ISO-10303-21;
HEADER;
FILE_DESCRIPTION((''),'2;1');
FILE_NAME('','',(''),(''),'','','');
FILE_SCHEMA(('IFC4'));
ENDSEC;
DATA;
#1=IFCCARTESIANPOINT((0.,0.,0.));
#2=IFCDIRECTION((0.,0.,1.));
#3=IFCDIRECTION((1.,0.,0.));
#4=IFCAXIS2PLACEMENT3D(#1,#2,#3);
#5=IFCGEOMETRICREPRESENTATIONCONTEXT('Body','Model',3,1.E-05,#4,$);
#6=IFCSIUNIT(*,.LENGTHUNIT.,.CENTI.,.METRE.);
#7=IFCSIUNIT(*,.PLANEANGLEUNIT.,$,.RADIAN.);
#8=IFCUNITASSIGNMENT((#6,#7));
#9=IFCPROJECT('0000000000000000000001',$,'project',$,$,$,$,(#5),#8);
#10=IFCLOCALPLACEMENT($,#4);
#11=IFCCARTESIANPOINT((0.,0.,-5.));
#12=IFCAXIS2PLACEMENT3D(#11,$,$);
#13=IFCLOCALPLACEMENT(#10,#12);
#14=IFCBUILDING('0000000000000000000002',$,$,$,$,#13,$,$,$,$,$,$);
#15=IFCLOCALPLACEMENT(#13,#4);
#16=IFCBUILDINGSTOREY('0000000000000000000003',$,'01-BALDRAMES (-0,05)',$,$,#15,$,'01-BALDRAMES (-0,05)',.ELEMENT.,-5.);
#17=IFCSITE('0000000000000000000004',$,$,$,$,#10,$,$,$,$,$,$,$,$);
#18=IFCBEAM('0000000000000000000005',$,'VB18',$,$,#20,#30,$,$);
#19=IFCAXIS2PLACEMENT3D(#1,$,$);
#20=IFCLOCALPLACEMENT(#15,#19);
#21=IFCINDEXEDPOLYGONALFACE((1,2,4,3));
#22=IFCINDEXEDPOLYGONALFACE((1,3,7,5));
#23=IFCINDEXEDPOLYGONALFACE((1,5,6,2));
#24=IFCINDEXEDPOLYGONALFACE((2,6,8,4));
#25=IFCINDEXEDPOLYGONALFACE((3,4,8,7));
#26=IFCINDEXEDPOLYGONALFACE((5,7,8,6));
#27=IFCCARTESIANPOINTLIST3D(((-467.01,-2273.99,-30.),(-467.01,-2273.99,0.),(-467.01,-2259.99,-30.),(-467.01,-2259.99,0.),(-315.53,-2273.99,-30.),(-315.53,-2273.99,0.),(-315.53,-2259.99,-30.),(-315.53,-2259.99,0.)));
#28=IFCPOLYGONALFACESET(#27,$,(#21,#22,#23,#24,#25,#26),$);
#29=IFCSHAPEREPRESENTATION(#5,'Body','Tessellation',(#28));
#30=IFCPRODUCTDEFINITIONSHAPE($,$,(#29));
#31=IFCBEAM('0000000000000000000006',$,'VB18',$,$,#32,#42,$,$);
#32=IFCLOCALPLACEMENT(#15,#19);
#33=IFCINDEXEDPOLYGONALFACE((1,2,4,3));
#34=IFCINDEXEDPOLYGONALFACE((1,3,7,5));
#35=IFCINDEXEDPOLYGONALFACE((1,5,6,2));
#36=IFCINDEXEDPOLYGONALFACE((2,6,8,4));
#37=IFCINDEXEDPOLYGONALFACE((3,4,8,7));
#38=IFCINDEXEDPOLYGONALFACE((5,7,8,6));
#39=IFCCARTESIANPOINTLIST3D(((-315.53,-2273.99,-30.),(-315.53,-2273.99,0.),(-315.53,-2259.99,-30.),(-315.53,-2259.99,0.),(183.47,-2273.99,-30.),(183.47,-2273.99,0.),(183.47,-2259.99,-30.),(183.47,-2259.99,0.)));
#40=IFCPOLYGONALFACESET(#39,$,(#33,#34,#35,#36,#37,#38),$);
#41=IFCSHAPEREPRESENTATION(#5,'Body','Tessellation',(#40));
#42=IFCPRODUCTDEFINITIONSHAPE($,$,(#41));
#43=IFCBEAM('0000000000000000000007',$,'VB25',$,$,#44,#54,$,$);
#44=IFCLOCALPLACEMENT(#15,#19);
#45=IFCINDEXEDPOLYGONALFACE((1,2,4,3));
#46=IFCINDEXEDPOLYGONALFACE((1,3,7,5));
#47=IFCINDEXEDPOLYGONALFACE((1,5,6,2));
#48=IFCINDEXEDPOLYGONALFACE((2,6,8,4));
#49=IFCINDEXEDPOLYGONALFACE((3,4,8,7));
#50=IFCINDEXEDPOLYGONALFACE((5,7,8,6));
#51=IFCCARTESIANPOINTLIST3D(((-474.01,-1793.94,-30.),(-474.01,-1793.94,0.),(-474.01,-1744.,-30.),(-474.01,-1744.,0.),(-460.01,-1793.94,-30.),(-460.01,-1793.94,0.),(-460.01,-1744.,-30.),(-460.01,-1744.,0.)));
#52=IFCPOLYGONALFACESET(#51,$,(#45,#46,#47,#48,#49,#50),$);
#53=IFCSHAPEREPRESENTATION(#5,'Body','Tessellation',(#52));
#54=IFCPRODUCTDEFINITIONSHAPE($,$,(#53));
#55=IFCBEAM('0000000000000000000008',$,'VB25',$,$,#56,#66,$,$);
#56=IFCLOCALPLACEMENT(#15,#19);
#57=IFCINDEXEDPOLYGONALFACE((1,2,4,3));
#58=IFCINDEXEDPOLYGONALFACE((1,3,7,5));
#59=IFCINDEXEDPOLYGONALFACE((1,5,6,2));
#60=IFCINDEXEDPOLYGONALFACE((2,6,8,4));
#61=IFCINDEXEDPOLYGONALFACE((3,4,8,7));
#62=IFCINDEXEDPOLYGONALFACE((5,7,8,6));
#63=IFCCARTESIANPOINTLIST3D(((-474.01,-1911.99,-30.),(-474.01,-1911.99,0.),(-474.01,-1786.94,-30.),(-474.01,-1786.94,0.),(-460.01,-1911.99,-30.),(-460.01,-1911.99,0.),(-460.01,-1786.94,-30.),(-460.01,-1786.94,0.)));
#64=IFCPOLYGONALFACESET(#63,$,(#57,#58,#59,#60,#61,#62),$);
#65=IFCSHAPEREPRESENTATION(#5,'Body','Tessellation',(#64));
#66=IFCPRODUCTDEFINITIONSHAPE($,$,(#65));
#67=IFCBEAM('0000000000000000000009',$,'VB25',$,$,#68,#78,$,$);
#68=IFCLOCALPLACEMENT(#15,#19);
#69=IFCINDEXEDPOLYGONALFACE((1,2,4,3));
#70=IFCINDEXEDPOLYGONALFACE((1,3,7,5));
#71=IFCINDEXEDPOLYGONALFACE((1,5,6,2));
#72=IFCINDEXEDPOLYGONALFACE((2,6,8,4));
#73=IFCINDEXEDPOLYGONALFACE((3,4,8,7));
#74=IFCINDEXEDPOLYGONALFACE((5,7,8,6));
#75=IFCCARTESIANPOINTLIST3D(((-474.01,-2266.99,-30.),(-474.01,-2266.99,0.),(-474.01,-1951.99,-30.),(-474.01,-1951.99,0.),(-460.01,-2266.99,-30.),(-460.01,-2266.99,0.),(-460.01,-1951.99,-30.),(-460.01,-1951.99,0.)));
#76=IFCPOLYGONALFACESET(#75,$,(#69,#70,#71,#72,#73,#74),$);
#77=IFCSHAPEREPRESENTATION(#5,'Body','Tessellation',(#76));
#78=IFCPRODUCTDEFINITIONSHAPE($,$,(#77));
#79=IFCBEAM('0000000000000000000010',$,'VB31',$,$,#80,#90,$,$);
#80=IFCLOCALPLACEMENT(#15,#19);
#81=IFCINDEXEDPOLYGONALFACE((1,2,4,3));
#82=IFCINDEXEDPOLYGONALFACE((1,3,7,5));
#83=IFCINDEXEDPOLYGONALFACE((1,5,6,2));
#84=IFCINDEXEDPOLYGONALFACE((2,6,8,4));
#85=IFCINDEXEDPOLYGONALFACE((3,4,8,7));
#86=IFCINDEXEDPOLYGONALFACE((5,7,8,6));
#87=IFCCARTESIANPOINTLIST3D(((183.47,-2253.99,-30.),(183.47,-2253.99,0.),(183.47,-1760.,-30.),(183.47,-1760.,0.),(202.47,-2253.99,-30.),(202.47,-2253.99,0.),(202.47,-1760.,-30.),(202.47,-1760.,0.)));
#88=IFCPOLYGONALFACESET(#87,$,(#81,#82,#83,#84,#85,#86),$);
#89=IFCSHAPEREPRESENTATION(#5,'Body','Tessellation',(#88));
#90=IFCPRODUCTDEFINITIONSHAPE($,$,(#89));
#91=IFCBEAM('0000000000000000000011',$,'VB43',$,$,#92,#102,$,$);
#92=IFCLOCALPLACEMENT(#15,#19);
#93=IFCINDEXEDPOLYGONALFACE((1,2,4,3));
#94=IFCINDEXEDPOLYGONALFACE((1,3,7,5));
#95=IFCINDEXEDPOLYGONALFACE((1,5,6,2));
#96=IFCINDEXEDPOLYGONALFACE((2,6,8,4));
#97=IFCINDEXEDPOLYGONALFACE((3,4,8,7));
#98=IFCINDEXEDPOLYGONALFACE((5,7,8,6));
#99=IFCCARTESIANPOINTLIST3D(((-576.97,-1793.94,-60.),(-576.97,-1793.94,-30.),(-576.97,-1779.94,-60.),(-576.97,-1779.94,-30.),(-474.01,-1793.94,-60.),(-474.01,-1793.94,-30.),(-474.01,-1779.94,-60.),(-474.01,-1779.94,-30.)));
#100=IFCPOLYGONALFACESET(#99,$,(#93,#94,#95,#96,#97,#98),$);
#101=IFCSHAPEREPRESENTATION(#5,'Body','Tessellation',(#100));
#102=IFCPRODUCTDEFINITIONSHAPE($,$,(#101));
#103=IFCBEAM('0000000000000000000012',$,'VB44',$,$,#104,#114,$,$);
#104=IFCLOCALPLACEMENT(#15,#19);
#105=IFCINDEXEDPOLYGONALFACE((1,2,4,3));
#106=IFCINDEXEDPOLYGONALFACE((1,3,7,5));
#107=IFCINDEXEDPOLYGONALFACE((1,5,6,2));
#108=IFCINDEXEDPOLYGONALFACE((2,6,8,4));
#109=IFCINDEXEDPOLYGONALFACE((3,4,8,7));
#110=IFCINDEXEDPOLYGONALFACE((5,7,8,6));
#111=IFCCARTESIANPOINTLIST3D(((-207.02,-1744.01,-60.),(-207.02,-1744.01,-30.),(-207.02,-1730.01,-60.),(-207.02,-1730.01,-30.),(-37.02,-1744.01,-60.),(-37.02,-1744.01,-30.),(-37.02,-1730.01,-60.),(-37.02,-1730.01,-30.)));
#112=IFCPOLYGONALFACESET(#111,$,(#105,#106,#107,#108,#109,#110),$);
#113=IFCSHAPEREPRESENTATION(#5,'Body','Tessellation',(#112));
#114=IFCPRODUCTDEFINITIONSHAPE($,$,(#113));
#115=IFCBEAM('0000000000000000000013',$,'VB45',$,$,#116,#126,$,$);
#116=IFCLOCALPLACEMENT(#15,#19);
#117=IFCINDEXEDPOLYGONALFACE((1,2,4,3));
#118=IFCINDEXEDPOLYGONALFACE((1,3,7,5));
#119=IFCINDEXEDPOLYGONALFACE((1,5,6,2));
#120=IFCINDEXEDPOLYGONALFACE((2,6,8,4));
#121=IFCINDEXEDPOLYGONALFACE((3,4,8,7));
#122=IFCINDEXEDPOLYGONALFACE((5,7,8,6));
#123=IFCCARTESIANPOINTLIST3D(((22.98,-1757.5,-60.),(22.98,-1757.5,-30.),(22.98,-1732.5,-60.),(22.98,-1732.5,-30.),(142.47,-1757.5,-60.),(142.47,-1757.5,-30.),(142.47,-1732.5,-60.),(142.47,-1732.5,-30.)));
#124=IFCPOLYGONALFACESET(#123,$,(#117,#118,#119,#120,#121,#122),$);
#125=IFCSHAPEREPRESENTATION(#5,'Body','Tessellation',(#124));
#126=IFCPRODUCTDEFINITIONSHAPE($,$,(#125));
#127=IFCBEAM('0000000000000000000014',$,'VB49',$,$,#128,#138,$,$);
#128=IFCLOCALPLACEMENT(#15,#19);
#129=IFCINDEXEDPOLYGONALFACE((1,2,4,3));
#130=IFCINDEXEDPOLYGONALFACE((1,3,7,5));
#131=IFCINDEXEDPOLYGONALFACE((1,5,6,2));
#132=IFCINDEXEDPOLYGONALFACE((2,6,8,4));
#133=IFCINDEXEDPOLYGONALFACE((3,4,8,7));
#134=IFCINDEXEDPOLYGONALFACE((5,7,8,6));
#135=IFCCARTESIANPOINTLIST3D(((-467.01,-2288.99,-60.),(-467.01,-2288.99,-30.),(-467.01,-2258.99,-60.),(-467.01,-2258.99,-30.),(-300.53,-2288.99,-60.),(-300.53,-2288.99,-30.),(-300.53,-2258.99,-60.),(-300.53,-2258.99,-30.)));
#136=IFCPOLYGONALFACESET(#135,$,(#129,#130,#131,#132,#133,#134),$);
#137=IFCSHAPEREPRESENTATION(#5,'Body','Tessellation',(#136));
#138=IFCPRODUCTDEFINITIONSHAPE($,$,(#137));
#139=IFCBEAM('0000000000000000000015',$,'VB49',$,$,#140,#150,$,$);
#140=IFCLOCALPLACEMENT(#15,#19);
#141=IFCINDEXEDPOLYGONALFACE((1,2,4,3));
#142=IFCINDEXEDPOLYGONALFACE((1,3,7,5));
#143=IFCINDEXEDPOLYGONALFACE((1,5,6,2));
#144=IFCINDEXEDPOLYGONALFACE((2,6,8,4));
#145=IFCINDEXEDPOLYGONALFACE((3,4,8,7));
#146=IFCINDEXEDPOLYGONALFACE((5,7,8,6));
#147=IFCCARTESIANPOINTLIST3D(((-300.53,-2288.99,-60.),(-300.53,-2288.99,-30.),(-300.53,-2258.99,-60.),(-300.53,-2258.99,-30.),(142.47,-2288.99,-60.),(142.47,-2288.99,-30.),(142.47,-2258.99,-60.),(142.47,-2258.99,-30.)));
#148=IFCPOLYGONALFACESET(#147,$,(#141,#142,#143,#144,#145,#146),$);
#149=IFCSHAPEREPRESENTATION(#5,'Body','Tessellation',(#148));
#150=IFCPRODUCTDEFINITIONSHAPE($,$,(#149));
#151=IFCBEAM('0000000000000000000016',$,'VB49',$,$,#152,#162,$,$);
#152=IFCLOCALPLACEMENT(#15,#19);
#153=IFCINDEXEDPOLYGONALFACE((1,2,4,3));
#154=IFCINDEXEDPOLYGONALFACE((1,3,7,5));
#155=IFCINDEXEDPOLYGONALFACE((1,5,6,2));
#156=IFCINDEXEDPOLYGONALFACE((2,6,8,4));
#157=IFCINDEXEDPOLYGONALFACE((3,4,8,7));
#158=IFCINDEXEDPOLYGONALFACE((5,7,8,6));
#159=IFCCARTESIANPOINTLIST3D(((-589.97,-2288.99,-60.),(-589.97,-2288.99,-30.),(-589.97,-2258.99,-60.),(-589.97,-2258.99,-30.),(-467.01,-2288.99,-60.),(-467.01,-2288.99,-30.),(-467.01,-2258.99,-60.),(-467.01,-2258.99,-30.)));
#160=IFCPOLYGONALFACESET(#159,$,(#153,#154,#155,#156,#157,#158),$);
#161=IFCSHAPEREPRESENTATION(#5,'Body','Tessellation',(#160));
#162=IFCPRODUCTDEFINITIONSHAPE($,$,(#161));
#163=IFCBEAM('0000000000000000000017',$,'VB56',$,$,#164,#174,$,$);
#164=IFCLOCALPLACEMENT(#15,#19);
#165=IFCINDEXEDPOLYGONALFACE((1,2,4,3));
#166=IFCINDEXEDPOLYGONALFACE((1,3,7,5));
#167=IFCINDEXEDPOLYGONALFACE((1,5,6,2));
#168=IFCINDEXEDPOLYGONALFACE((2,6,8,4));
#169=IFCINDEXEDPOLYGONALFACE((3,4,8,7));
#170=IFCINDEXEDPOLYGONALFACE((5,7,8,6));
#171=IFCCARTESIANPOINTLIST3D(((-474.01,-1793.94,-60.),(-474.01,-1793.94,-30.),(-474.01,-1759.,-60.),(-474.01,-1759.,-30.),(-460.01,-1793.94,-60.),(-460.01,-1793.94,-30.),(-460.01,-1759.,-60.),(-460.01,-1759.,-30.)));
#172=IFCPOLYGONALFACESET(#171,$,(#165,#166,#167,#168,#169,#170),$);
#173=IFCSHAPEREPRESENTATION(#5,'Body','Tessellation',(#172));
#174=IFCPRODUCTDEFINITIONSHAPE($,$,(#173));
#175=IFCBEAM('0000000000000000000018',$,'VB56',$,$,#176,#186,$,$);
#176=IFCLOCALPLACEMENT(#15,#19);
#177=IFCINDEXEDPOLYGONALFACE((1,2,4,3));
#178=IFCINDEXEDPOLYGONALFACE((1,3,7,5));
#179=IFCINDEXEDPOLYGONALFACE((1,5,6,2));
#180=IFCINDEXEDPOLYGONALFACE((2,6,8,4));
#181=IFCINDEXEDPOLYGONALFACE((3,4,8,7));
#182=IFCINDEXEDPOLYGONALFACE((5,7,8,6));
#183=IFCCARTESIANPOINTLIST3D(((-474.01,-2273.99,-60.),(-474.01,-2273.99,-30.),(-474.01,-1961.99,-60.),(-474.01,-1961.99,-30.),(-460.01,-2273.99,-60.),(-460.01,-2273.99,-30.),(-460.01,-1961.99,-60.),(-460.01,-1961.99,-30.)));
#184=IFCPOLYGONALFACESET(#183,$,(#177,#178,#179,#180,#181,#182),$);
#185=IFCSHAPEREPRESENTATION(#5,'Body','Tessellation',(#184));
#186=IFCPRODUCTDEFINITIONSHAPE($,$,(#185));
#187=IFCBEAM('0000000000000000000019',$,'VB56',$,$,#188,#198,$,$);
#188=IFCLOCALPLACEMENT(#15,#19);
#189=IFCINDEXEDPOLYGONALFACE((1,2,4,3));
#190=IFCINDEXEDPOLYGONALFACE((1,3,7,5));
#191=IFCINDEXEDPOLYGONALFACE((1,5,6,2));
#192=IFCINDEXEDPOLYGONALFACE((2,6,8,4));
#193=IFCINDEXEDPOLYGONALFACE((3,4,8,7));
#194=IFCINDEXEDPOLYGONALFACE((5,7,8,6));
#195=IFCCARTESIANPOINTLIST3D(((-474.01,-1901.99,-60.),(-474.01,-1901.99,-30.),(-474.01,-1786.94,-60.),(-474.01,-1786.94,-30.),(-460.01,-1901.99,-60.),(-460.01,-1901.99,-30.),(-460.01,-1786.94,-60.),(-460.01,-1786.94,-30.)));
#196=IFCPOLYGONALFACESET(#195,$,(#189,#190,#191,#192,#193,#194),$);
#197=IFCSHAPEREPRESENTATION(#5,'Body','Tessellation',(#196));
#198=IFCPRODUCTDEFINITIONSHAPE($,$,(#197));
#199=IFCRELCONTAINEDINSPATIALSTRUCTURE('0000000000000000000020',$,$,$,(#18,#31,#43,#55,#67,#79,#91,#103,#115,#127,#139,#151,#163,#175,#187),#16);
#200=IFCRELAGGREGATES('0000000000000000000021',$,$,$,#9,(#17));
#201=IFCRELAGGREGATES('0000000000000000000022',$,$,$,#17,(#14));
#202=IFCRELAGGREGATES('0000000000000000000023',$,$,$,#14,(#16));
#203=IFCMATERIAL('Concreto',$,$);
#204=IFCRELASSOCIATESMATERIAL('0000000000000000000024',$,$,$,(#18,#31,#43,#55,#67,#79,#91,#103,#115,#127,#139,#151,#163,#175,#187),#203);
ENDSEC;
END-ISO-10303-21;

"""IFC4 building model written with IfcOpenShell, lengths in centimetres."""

from ifc_helpers import new_model, si_unit, frame, origin_with_axes, origin_2d_with_axis, place, context, project, spatial, rectangle, extrude, material, element, save


model = new_model("IFC4")

# Units and contexts
model_context = context("Model", 3, precision=1e-05, world=origin_with_axes(), identifier="Body")
ifc_project = project(units=[si_unit("LENGTHUNIT", "METRE", prefix="CENTI"), si_unit("PLANEANGLEUNIT", "RADIAN")], contexts=[model_context])

# Site, building, storey
site_placement = place(None, origin_with_axes())
site = spatial("IfcSite", under=ifc_project, at=site_placement)
building_placement = place(site_placement, frame((0.0, 0.0, -5.0)))
building = spatial("IfcBuilding", under=site, at=building_placement)
storey_placement = place(building_placement, origin_with_axes())
storey = spatial("IfcBuildingStorey", under=building, at=storey_placement, Name="01-BALDRAMES (-0,05)", LongName="01-BALDRAMES (-0,05)", CompositionType="ELEMENT", Elevation=-5.0)

# Shared definitions
ifc_material = material(Name="Concreto")

# Beams
beam_1_placement = place(storey_placement, frame((-391.27, -2266.99, 0.0), z_axis=(0.0, 0.0, 1.0), x_axis=(1.0, 0.0, 0.0)))
element("IfcBeam", 1, at=beam_1_placement, inside=storey, material=ifc_material, Name="VB18", context=model_context, shape_type="SolidModel", body=[
    extrude(rectangle(XDim=14.0, YDim=30.0, at=origin_2d_with_axis()), frame((-75.74, 0.0, -15.0), z_axis=(1.0, 0.0, 0.0), x_axis=(0.0, -1.0, 0.0)), (0.0, 0.0, 1.0), 151.48),
])
beam_2_placement = place(storey_placement, frame((-66.03, -2266.99, 0.0), z_axis=(0.0, 0.0, 1.0), x_axis=(1.0, 0.0, 0.0)))
element("IfcBeam", 2, at=beam_2_placement, inside=storey, material=ifc_material, Name="VB18", context=model_context, shape_type="SolidModel", body=[
    extrude(rectangle(XDim=14.0, YDim=30.0, at=origin_2d_with_axis()), frame((-249.5, 0.0, -15.0), z_axis=(1.0, 0.0, 0.0), x_axis=(0.0, -1.0, 0.0)), (0.0, 0.0, 1.0), 499.0),
])
beam_3_placement = place(storey_placement, frame((-467.01, -1768.97, 0.0), z_axis=(0.0, 0.0, 1.0), x_axis=(1.0, 0.0, 0.0)))
element("IfcBeam", 3, at=beam_3_placement, inside=storey, material=ifc_material, Name="VB25", context=model_context, shape_type="SolidModel", body=[
    extrude(rectangle(XDim=14.0, YDim=30.0, at=origin_2d_with_axis()), frame((0.0, -24.97, -15.0), z_axis=(0.0, 1.0, 0.0), x_axis=(1.0, 0.0, 0.0)), (0.0, 0.0, 1.0), 49.94),
])
beam_4_placement = place(storey_placement, frame((-467.01, -1849.46, 0.0), z_axis=(0.0, 0.0, 1.0), x_axis=(1.0, 0.0, 0.0)))
element("IfcBeam", 4, at=beam_4_placement, inside=storey, material=ifc_material, Name="VB25", context=model_context, shape_type="SolidModel", body=[
    extrude(rectangle(XDim=14.0, YDim=30.0, at=origin_2d_with_axis()), frame((0.0, -62.52, -15.0), z_axis=(0.0, 1.0, 0.0), x_axis=(1.0, 0.0, 0.0)), (0.0, 0.0, 1.0), 125.05),
])
beam_5_placement = place(storey_placement, frame((-467.01, -2109.49, 0.0), z_axis=(0.0, 0.0, 1.0), x_axis=(1.0, 0.0, 0.0)))
element("IfcBeam", 5, at=beam_5_placement, inside=storey, material=ifc_material, Name="VB25", context=model_context, shape_type="SolidModel", body=[
    extrude(rectangle(XDim=14.0, YDim=30.0, at=origin_2d_with_axis()), frame((0.0, -157.5, -15.0), z_axis=(0.0, 1.0, 0.0), x_axis=(1.0, 0.0, 0.0)), (0.0, 0.0, 1.0), 315.0),
])
beam_6_placement = place(storey_placement, frame((192.97, -2006.99, 0.0), z_axis=(0.0, 0.0, 1.0), x_axis=(1.0, 0.0, 0.0)))
element("IfcBeam", 6, at=beam_6_placement, inside=storey, material=ifc_material, Name="VB31", context=model_context, shape_type="SolidModel", body=[
    extrude(rectangle(XDim=19.0, YDim=30.0, at=origin_2d_with_axis()), frame((0.0, -247.0, -15.0), z_axis=(0.0, 1.0, 0.0), x_axis=(1.0, 0.0, 0.0)), (0.0, 0.0, 1.0), 493.99),
])
beam_7_placement = place(storey_placement, frame((-525.49, -1786.94, -30.0), z_axis=(0.0, 0.0, 1.0), x_axis=(1.0, 0.0, 0.0)))
element("IfcBeam", 7, at=beam_7_placement, inside=storey, material=ifc_material, Name="VB43", context=model_context, shape_type="SolidModel", body=[
    extrude(rectangle(XDim=14.0, YDim=30.0, at=origin_2d_with_axis()), frame((-51.48, 0.0, -15.0), z_axis=(1.0, 0.0, 0.0), x_axis=(0.0, -1.0, 0.0)), (0.0, 0.0, 1.0), 102.96),
])
beam_8_placement = place(storey_placement, frame((-122.02, -1737.01, -30.0), z_axis=(0.0, 0.0, 1.0), x_axis=(1.0, 0.0, 0.0)))
element("IfcBeam", 8, at=beam_8_placement, inside=storey, material=ifc_material, Name="VB44", context=model_context, shape_type="SolidModel", body=[
    extrude(rectangle(XDim=14.0, YDim=30.0, at=origin_2d_with_axis()), frame((-85.0, 0.0, -15.0), z_axis=(1.0, 0.0, 0.0), x_axis=(0.0, -1.0, 0.0)), (0.0, 0.0, 1.0), 170.0),
])
beam_9_placement = place(storey_placement, frame((82.72, -1745.0, -30.0), z_axis=(0.0, 0.0, 1.0), x_axis=(1.0, 0.0, 0.0)))
element("IfcBeam", 9, at=beam_9_placement, inside=storey, material=ifc_material, Name="VB45", context=model_context, shape_type="SolidModel", body=[
    extrude(rectangle(XDim=25.0, YDim=30.0, at=origin_2d_with_axis()), frame((-59.74, 0.0, -15.0), z_axis=(1.0, 0.0, 0.0), x_axis=(0.0, -1.0, 0.0)), (0.0, 0.0, 1.0), 119.49),
])
beam_10_placement = place(storey_placement, frame((-383.77, -2273.99, -30.0), z_axis=(0.0, 0.0, 1.0), x_axis=(1.0, 0.0, 0.0)))
element("IfcBeam", 10, at=beam_10_placement, inside=storey, material=ifc_material, Name="VB49", context=model_context, shape_type="SolidModel", body=[
    extrude(rectangle(XDim=30.0, YDim=30.0, at=origin_2d_with_axis()), frame((-83.24, 0.0, -15.0), z_axis=(1.0, 0.0, 0.0), x_axis=(0.0, -1.0, 0.0)), (0.0, 0.0, 1.0), 166.48),
])
beam_11_placement = place(storey_placement, frame((-79.03, -2273.99, -30.0), z_axis=(0.0, 0.0, 1.0), x_axis=(1.0, 0.0, 0.0)))
element("IfcBeam", 11, at=beam_11_placement, inside=storey, material=ifc_material, Name="VB49", context=model_context, shape_type="SolidModel", body=[
    extrude(rectangle(XDim=30.0, YDim=30.0, at=origin_2d_with_axis()), frame((-221.5, 0.0, -15.0), z_axis=(1.0, 0.0, 0.0), x_axis=(0.0, -1.0, 0.0)), (0.0, 0.0, 1.0), 443.0),
])
beam_12_placement = place(storey_placement, frame((-528.49, -2273.99, -30.0), z_axis=(0.0, 0.0, 1.0), x_axis=(1.0, 0.0, 0.0)))
element("IfcBeam", 12, at=beam_12_placement, inside=storey, material=ifc_material, Name="VB49", context=model_context, shape_type="SolidModel", body=[
    extrude(rectangle(XDim=30.0, YDim=30.0, at=origin_2d_with_axis()), frame((-61.48, 0.0, -15.0), z_axis=(1.0, 0.0, 0.0), x_axis=(0.0, -1.0, 0.0)), (0.0, 0.0, 1.0), 122.96),
])
beam_13_placement = place(storey_placement, frame((-467.01, -1776.47, -30.0), z_axis=(0.0, 0.0, 1.0), x_axis=(1.0, 0.0, 0.0)))
element("IfcBeam", 13, at=beam_13_placement, inside=storey, material=ifc_material, Name="VB56", context=model_context, shape_type="SolidModel", body=[
    extrude(rectangle(XDim=14.0, YDim=30.0, at=origin_2d_with_axis()), frame((0.0, -17.47, -15.0), z_axis=(0.0, 1.0, 0.0), x_axis=(1.0, 0.0, 0.0)), (0.0, 0.0, 1.0), 34.94),
])
beam_14_placement = place(storey_placement, frame((-467.01, -2117.99, -30.0), z_axis=(0.0, 0.0, 1.0), x_axis=(1.0, 0.0, 0.0)))
element("IfcBeam", 14, at=beam_14_placement, inside=storey, material=ifc_material, Name="VB56", context=model_context, shape_type="SolidModel", body=[
    extrude(rectangle(XDim=14.0, YDim=30.0, at=origin_2d_with_axis()), frame((0.0, -156.0, -15.0), z_axis=(0.0, 1.0, 0.0), x_axis=(1.0, 0.0, 0.0)), (0.0, 0.0, 1.0), 312.0),
])
beam_15_placement = place(storey_placement, frame((-467.01, -1844.46, -30.0), z_axis=(0.0, 0.0, 1.0), x_axis=(1.0, 0.0, 0.0)))
element("IfcBeam", 15, at=beam_15_placement, inside=storey, material=ifc_material, Name="VB56", context=model_context, shape_type="SolidModel", body=[
    extrude(rectangle(XDim=14.0, YDim=30.0, at=origin_2d_with_axis()), frame((0.0, -57.52, -15.0), z_axis=(0.0, 1.0, 0.0), x_axis=(1.0, 0.0, 0.0)), (0.0, 0.0, 1.0), 115.05),
])

save(model, "model.ifc")
